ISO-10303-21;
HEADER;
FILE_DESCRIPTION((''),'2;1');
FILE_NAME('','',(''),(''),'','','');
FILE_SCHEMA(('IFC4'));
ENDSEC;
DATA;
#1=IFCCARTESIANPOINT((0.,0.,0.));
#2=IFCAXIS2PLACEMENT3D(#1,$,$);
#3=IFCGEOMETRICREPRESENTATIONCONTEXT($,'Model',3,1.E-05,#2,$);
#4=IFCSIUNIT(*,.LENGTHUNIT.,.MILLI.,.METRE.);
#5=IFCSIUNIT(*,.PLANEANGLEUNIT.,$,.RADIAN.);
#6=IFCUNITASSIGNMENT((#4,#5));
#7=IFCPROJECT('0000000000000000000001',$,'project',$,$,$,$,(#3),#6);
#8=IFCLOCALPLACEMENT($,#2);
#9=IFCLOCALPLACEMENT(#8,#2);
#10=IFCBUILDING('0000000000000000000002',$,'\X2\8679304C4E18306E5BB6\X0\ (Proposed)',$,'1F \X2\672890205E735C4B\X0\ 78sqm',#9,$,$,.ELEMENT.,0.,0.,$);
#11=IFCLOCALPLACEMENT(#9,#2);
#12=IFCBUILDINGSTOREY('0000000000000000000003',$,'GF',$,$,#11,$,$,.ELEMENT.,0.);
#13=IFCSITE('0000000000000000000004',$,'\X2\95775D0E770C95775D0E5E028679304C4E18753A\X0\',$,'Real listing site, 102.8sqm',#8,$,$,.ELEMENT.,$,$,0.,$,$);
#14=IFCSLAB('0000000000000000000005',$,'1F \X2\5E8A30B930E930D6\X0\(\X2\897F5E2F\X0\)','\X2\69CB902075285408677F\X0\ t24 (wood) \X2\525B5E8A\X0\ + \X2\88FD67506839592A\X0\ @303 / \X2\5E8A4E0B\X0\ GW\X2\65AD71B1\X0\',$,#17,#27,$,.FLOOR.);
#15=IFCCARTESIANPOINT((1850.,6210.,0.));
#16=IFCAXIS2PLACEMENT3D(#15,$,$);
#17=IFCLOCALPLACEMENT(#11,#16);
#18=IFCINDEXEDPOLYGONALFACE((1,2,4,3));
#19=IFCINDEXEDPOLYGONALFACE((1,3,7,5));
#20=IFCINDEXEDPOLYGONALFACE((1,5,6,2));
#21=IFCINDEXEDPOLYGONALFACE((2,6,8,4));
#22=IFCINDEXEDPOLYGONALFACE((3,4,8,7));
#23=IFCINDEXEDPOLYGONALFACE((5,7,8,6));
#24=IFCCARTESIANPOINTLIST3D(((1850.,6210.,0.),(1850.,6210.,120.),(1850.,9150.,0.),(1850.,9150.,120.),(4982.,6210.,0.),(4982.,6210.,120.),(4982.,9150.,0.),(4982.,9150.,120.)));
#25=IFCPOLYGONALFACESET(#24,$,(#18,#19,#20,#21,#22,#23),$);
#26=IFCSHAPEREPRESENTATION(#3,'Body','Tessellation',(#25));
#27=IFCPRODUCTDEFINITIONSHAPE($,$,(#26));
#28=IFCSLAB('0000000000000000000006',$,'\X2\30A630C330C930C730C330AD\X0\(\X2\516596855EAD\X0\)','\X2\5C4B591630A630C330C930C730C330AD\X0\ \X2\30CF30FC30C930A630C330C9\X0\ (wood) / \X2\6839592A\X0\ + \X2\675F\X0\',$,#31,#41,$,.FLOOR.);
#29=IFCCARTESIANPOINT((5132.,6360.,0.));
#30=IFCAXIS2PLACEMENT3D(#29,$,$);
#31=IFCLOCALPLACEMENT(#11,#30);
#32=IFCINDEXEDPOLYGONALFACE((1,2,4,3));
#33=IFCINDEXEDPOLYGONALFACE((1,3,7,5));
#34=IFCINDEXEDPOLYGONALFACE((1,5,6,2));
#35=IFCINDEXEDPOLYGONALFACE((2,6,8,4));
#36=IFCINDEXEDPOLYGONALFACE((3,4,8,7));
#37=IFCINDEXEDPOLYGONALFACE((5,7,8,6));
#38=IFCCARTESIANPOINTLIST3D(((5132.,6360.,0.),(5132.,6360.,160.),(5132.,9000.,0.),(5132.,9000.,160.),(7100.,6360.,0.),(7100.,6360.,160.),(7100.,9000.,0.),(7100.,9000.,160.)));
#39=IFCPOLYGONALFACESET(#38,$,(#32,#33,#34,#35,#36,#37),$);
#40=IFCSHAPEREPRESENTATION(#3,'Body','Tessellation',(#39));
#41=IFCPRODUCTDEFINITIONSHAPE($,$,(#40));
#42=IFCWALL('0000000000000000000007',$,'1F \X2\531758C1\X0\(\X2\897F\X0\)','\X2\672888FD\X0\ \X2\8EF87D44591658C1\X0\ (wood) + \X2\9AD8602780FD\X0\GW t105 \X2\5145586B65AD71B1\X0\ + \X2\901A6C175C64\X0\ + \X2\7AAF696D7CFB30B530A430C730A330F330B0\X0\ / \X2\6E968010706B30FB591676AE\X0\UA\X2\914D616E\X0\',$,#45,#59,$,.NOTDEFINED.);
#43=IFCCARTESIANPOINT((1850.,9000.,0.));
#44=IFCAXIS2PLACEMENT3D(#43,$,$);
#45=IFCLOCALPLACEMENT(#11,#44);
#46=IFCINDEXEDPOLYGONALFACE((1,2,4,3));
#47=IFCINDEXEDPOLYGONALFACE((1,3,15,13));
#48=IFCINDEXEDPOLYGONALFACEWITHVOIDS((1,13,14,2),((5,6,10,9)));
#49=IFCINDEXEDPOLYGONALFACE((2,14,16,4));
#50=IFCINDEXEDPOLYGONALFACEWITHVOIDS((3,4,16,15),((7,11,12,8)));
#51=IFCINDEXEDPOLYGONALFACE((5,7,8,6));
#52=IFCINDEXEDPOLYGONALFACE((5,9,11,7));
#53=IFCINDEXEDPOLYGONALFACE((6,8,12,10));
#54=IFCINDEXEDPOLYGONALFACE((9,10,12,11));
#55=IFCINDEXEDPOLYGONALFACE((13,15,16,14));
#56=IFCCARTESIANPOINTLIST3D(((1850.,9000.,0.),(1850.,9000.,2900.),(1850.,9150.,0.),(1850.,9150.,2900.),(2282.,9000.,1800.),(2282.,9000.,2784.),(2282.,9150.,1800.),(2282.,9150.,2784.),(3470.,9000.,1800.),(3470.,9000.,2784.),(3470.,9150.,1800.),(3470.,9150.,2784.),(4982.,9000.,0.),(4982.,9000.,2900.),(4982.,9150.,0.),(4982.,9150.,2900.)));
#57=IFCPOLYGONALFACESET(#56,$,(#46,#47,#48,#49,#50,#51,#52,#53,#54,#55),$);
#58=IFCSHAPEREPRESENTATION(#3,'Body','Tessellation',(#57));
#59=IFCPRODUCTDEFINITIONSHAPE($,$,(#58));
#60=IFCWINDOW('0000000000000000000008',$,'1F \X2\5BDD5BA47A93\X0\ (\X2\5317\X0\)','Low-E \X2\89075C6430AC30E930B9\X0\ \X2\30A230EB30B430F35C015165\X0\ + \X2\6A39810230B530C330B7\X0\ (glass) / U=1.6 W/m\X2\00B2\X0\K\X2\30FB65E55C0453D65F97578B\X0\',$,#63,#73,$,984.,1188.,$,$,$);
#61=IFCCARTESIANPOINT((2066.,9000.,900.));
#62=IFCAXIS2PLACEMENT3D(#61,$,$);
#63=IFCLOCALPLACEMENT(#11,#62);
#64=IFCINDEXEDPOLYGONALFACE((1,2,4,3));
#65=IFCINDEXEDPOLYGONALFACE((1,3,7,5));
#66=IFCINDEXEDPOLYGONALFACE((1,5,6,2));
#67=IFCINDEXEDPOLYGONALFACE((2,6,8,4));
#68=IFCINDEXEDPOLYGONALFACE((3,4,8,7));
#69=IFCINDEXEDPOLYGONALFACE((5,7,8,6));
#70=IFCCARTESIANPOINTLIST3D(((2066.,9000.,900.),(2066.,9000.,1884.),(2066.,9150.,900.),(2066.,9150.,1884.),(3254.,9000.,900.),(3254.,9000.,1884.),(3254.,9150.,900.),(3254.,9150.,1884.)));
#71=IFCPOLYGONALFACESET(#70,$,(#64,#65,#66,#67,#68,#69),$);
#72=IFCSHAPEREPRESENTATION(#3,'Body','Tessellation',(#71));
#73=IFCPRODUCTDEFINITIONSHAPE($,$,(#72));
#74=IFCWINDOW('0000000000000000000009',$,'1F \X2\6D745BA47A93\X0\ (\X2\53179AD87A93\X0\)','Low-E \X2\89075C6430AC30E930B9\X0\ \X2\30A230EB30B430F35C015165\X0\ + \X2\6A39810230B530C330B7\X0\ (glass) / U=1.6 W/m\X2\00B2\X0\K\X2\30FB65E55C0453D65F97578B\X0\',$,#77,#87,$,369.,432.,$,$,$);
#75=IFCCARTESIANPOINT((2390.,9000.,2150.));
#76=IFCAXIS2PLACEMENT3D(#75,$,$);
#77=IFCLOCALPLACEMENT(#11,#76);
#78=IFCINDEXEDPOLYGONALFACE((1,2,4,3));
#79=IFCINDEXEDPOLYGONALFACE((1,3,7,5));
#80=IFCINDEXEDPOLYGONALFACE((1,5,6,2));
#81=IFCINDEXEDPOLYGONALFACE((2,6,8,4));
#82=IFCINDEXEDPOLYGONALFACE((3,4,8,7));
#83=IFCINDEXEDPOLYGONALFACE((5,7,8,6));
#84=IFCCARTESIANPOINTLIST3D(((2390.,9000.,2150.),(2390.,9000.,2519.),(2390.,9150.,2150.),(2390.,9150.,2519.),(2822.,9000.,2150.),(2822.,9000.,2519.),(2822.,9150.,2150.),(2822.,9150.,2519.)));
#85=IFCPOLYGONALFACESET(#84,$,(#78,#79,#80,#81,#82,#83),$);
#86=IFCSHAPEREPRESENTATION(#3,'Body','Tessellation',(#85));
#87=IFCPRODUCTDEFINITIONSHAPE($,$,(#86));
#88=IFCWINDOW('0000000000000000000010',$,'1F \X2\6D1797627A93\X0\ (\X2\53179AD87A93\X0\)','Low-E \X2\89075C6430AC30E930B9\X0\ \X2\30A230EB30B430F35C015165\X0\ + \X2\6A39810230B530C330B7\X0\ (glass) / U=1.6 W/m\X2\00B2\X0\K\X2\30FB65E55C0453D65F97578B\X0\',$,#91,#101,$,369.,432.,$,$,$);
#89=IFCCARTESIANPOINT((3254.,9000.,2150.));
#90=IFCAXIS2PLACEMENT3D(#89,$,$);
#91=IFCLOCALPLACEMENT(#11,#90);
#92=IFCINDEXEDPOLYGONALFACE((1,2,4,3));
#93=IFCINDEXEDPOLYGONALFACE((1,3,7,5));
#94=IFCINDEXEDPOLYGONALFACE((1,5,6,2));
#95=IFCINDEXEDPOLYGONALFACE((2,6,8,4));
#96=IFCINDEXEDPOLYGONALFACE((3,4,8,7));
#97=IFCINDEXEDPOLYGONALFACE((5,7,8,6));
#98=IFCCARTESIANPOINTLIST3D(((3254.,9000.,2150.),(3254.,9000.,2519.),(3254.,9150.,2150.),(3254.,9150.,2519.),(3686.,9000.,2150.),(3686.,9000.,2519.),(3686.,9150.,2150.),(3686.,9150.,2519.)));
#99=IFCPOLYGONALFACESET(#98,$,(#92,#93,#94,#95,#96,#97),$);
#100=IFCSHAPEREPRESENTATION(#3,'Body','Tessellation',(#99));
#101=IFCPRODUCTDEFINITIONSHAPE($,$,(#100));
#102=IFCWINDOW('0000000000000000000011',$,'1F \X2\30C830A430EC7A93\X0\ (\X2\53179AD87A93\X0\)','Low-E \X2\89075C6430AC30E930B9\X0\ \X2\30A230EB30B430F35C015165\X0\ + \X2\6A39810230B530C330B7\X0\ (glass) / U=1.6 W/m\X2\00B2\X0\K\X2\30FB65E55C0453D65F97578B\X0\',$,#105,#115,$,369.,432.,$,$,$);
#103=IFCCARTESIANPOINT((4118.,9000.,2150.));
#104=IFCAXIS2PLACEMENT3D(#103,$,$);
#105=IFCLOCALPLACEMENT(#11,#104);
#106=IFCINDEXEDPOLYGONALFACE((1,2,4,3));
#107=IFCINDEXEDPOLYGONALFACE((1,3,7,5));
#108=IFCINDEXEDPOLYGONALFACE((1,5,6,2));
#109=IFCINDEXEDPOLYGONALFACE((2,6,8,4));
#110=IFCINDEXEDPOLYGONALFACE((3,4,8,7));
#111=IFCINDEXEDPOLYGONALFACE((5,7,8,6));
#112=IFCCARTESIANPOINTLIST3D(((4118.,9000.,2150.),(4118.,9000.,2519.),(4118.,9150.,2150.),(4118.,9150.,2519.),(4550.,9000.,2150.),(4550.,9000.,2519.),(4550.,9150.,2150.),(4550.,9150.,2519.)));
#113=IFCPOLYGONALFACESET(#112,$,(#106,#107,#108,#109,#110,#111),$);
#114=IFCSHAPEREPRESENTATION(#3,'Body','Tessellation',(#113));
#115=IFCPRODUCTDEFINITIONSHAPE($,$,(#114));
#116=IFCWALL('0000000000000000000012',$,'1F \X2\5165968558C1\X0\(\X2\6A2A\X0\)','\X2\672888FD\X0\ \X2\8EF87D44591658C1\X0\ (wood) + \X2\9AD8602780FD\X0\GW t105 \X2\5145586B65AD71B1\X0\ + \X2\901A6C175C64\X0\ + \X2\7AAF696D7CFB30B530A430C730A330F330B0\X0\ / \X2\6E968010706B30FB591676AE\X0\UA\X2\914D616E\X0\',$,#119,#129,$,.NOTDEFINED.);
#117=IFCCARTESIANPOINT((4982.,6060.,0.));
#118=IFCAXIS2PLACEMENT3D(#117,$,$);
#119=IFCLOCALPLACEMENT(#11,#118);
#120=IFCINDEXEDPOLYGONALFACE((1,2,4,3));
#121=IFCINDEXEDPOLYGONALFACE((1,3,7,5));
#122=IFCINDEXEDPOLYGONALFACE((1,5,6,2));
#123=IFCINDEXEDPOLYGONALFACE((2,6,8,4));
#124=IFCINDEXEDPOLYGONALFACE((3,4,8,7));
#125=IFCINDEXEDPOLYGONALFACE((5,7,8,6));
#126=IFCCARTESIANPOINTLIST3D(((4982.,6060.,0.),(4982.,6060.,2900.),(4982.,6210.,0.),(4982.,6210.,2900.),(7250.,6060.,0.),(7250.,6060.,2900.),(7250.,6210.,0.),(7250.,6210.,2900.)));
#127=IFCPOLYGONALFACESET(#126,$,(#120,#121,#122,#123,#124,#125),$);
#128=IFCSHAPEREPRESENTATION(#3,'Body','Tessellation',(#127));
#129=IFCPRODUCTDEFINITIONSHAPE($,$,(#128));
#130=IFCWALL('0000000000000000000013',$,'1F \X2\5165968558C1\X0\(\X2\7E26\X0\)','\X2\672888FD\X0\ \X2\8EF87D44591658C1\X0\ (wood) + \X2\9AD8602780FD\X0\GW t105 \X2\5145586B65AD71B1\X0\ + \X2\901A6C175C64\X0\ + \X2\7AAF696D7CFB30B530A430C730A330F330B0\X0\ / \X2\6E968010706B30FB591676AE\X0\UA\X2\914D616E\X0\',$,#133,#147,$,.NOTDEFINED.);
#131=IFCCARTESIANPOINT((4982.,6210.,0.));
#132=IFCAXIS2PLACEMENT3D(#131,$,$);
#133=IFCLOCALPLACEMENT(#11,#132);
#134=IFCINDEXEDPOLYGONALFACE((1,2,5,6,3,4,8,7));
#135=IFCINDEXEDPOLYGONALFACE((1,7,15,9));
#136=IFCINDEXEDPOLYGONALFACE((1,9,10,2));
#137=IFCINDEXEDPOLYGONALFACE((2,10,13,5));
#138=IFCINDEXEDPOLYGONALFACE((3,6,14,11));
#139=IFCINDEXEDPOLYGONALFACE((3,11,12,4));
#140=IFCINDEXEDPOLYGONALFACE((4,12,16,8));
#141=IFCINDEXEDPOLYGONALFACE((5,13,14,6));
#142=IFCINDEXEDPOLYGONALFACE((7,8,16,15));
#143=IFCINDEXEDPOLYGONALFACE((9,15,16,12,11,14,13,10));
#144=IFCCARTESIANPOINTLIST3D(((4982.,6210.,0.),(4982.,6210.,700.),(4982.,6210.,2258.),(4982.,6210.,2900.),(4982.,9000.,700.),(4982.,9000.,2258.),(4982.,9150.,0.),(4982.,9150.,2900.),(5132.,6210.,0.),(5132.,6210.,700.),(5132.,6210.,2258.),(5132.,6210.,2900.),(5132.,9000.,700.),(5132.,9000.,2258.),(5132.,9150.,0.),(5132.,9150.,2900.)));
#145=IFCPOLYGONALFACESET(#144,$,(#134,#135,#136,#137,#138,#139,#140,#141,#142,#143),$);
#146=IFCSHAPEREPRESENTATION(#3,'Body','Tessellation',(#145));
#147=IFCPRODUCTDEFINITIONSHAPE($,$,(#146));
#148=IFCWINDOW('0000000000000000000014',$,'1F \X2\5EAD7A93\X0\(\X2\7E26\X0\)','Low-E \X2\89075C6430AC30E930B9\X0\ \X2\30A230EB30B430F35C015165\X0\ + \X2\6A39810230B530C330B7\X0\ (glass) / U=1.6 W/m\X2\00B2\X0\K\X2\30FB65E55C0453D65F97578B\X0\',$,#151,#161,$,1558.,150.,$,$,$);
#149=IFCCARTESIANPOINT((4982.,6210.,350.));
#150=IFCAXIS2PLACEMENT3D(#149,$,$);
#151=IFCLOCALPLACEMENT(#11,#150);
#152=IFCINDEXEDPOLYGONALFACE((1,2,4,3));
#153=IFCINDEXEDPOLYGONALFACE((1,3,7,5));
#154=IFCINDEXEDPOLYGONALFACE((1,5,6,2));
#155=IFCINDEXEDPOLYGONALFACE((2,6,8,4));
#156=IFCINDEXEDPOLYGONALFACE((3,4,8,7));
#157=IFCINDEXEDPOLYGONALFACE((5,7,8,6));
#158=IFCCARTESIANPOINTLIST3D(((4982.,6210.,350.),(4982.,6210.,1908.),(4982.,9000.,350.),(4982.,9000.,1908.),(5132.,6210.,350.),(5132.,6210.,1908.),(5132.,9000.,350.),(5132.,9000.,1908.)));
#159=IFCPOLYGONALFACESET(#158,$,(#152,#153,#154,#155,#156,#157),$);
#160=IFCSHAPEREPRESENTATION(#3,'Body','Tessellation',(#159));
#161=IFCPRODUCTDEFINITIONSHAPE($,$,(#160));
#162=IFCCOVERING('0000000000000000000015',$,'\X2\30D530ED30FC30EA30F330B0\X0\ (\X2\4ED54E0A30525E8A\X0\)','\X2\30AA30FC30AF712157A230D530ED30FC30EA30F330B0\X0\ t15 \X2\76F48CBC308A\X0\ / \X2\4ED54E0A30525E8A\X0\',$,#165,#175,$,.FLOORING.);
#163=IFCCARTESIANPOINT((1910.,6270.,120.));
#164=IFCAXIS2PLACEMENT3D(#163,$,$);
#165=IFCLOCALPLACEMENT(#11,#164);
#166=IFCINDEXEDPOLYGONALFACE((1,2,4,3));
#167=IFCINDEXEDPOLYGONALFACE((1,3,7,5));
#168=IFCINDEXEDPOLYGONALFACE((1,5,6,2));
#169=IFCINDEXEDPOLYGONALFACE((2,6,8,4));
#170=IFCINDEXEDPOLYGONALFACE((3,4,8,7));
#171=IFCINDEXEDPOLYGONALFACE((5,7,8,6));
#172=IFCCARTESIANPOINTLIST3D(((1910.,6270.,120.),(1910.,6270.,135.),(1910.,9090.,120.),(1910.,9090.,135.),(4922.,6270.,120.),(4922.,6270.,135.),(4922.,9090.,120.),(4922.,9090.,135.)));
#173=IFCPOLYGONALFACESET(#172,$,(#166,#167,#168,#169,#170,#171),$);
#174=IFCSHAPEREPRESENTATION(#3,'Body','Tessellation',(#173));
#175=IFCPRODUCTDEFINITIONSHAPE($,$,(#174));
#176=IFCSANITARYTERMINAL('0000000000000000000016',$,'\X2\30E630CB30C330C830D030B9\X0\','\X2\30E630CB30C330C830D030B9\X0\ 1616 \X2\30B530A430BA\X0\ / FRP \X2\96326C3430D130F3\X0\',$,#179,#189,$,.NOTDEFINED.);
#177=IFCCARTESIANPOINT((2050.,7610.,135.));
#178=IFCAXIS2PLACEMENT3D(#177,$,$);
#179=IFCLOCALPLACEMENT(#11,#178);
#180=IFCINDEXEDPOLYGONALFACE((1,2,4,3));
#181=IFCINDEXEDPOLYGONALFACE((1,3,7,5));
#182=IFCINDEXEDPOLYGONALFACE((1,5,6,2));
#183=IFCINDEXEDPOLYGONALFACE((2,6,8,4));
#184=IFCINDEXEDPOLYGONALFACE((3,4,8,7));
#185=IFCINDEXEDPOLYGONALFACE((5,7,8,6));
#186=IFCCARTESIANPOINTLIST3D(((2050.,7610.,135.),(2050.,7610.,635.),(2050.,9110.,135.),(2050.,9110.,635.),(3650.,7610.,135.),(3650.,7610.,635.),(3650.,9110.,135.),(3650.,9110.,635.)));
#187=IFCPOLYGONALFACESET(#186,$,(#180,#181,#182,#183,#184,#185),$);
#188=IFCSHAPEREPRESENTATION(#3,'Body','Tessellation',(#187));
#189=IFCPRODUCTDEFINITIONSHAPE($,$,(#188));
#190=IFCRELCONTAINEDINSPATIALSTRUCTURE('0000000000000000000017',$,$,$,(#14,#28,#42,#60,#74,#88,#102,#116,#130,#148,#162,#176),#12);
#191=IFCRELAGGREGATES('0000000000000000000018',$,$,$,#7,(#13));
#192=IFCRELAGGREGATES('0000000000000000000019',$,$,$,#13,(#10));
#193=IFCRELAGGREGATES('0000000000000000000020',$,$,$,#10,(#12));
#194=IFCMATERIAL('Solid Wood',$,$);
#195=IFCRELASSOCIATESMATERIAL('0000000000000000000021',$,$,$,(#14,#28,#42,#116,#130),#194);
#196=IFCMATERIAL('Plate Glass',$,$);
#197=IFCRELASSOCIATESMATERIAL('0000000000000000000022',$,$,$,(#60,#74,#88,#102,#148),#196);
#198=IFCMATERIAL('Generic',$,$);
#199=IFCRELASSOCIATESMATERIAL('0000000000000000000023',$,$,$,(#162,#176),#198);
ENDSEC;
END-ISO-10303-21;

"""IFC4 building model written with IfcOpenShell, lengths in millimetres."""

from ifc_helpers import new_model, si_unit, frame, frame_2d, origin, place, context, project, spatial, rectangle, extrude, material, element, fill, save


model = new_model("IFC4")

# Units and contexts
model_context = context("Model", 3, precision=1e-05, world=origin())
ifc_project = project(units=[si_unit("LENGTHUNIT", "METRE", prefix="MILLI"), si_unit("PLANEANGLEUNIT", "RADIAN")], contexts=[model_context])

# Site, building, storey
site_placement = place(None, origin())
site = spatial("IfcSite", under=ifc_project, at=site_placement, Name="長崎県長崎市虹が丘町", ObjectType="Real listing site, 102.8sqm", CompositionType="ELEMENT", RefElevation=0.0)
building_placement = place(site_placement, origin())
building = spatial("IfcBuilding", under=site, at=building_placement, Name="虹が丘の家 (Proposed)", ObjectType="1F 木造平屋 78sqm", CompositionType="ELEMENT", ElevationOfRefHeight=0.0, ElevationOfTerrain=0.0)
storey_placement = place(building_placement, origin())
storey = spatial("IfcBuildingStorey", under=building, at=storey_placement, Name="GF", CompositionType="ELEMENT", Elevation=0.0)

# Slabs
ifc_material_1 = material(Name="Solid Wood")
slab_1_placement = place(storey_placement, frame((1850.0, 6210.0, 0.0)))
element("IfcSlab", 1, at=slab_1_placement, inside=storey, material=ifc_material_1, Name="1F 床スラブ(西帯)", Description="構造用合板 t24 (wood) 剛床 + 製材根太 @303 / 床下 GW断熱", PredefinedType="FLOOR", context=model_context, shape_type="SweptSolid", body=[
    extrude(rectangle(XDim=3132.0, YDim=2940.0, at=frame_2d((1566.0, 1470.0))), frame((1850.0, 6210.0, 0.0)), (0.0, 0.0, 1.0), 120.0),
])
slab_2_placement = place(storey_placement, frame((5132.0, 6360.0, 0.0)))
element("IfcSlab", 2, at=slab_2_placement, inside=storey, material=ifc_material_1, Name="ウッドデッキ(入隅庭)", Description="屋外ウッドデッキ ハードウッド (wood) / 根太 + 束", PredefinedType="FLOOR", context=model_context, shape_type="SweptSolid", body=[
    extrude(rectangle(XDim=1968.0, YDim=2640.0, at=frame_2d((984.0, 1320.0))), frame((5132.0, 6360.0, 0.0)), (0.0, 0.0, 1.0), 160.0),
])

# Wall, openings, windows
wall_1_placement = place(storey_placement, frame((1850.0, 9000.0, 0.0)))
wall_1 = element("IfcWall", 3, at=wall_1_placement, inside=storey, material=ifc_material_1, Name="1F 北壁(西)", Description="木製 軸組外壁 (wood) + 高性能GW t105 充填断熱 + 通気層 + 窯業系サイディング / 準耐火・外皮UA配慮", PredefinedType="NOTDEFINED", context=model_context, shape_type="SweptSolid", body=[
    extrude(rectangle(XDim=3132.0, YDim=150.0, at=frame_2d((1566.0, 75.0))), frame((1850.0, 9000.0, 0.0)), (0.0, 0.0, 1.0), 2900.0),
])
opening_1_placement = place(storey_placement, frame((2066.0, 9000.0, 900.0)))
opening_1 = element("IfcOpeningElement", 4, at=opening_1_placement, cuts=wall_1, PredefinedType="NOTDEFINED", context=model_context, shape_type="SweptSolid", body=[
    extrude(rectangle(XDim=1188.0, YDim=150.0, at=frame_2d((594.0, 75.0))), frame((2066.0, 9000.0, 900.0)), (0.0, 0.0, 1.0), 984.0),
])
opening_2_placement = place(storey_placement, frame((2390.0, 9000.0, 2150.0)))
opening_2 = element("IfcOpeningElement", 5, at=opening_2_placement, cuts=wall_1, PredefinedType="NOTDEFINED", context=model_context, shape_type="SweptSolid", body=[
    extrude(rectangle(XDim=432.0, YDim=150.0, at=frame_2d((216.0, 75.0))), frame((2390.0, 9000.0, 2150.0)), (0.0, 0.0, 1.0), 369.0),
])
opening_3_placement = place(storey_placement, frame((3254.0, 9000.0, 2150.0)))
opening_3 = element("IfcOpeningElement", 6, at=opening_3_placement, cuts=wall_1, PredefinedType="NOTDEFINED", context=model_context, shape_type="SweptSolid", body=[
    extrude(rectangle(XDim=432.0, YDim=150.0, at=frame_2d((216.0, 75.0))), frame((3254.0, 9000.0, 2150.0)), (0.0, 0.0, 1.0), 369.0),
])
opening_4_placement = place(storey_placement, frame((4118.0, 9000.0, 2150.0)))
opening_4 = element("IfcOpeningElement", 7, at=opening_4_placement, cuts=wall_1, PredefinedType="NOTDEFINED", context=model_context, shape_type="SweptSolid", body=[
    extrude(rectangle(XDim=432.0, YDim=150.0, at=frame_2d((216.0, 75.0))), frame((4118.0, 9000.0, 2150.0)), (0.0, 0.0, 1.0), 369.0),
])
ifc_material_2 = material(Name="Plate Glass")
window_1_placement = place(storey_placement, frame((2066.0, 9000.0, 900.0)))
window_1 = element("IfcWindow", 8, at=window_1_placement, inside=storey, material=ifc_material_2, Name="1F 寝室窓 (北)", Description="Low-E 複層ガラス アルゴン封入 + 樹脂サッシ (glass) / U=1.6 W/m²K・日射取得型", OverallHeight=984.0, OverallWidth=1188.0, context=model_context, shape_type="SweptSolid", body=[
    extrude(rectangle(XDim=1188.0, YDim=150.0, at=frame_2d((594.0, 75.0))), frame((2066.0, 9000.0, 900.0)), (0.0, 0.0, 1.0), 984.0),
])
fill(opening_1, window_1)
window_2_placement = place(storey_placement, frame((2390.0, 9000.0, 2150.0)))
window_2 = element("IfcWindow", 9, at=window_2_placement, inside=storey, material=ifc_material_2, Name="1F 浴室窓 (北高窓)", Description="Low-E 複層ガラス アルゴン封入 + 樹脂サッシ (glass) / U=1.6 W/m²K・日射取得型", OverallHeight=369.0, OverallWidth=432.0, context=model_context, shape_type="SweptSolid", body=[
    extrude(rectangle(XDim=432.0, YDim=150.0, at=frame_2d((216.0, 75.0))), frame((2390.0, 9000.0, 2150.0)), (0.0, 0.0, 1.0), 369.0),
])
fill(opening_2, window_2)
window_3_placement = place(storey_placement, frame((3254.0, 9000.0, 2150.0)))
window_3 = element("IfcWindow", 10, at=window_3_placement, inside=storey, material=ifc_material_2, Name="1F 洗面窓 (北高窓)", Description="Low-E 複層ガラス アルゴン封入 + 樹脂サッシ (glass) / U=1.6 W/m²K・日射取得型", OverallHeight=369.0, OverallWidth=432.0, context=model_context, shape_type="SweptSolid", body=[
    extrude(rectangle(XDim=432.0, YDim=150.0, at=frame_2d((216.0, 75.0))), frame((3254.0, 9000.0, 2150.0)), (0.0, 0.0, 1.0), 369.0),
])
fill(opening_3, window_3)
window_4_placement = place(storey_placement, frame((4118.0, 9000.0, 2150.0)))
window_4 = element("IfcWindow", 11, at=window_4_placement, inside=storey, material=ifc_material_2, Name="1F トイレ窓 (北高窓)", Description="Low-E 複層ガラス アルゴン封入 + 樹脂サッシ (glass) / U=1.6 W/m²K・日射取得型", OverallHeight=369.0, OverallWidth=432.0, context=model_context, shape_type="SweptSolid", body=[
    extrude(rectangle(XDim=432.0, YDim=150.0, at=frame_2d((216.0, 75.0))), frame((4118.0, 9000.0, 2150.0)), (0.0, 0.0, 1.0), 369.0),
])
fill(opening_4, window_4)

# Wall
wall_2_placement = place(storey_placement, frame((4982.0, 6060.0, 0.0)))
element("IfcWall", 12, at=wall_2_placement, inside=storey, material=ifc_material_1, Name="1F 入隅壁(横)", Description="木製 軸組外壁 (wood) + 高性能GW t105 充填断熱 + 通気層 + 窯業系サイディング / 準耐火・外皮UA配慮", PredefinedType="NOTDEFINED", context=model_context, shape_type="SweptSolid", body=[
    extrude(rectangle(XDim=2268.0, YDim=150.0, at=frame_2d((1134.0, 75.0))), frame((4982.0, 6060.0, 0.0)), (0.0, 0.0, 1.0), 2900.0),
])

# Wall, opening, window
wall_3_placement = place(storey_placement, frame((4982.0, 6210.0, 0.0)))
wall_3 = element("IfcWall", 13, at=wall_3_placement, inside=storey, material=ifc_material_1, Name="1F 入隅壁(縦)", Description="木製 軸組外壁 (wood) + 高性能GW t105 充填断熱 + 通気層 + 窯業系サイディング / 準耐火・外皮UA配慮", PredefinedType="NOTDEFINED", context=model_context, shape_type="SweptSolid", body=[
    extrude(rectangle(XDim=150.0, YDim=2940.0, at=frame_2d((75.0, 1470.0))), frame((4982.0, 6210.0, 0.0)), (0.0, 0.0, 1.0), 2900.0),
])
opening_5_placement = place(storey_placement, frame((4982.0, 6210.0, 350.0)))
opening_5 = element("IfcOpeningElement", 14, at=opening_5_placement, cuts=wall_3, PredefinedType="NOTDEFINED", context=model_context, shape_type="SweptSolid", body=[
    extrude(rectangle(XDim=150.0, YDim=2790.0, at=frame_2d((75.0, 1395.0))), frame((4982.0, 6210.0, 350.0)), (0.0, 0.0, 1.0), 1558.0),
])
window_5_placement = place(storey_placement, frame((4982.0, 6210.0, 350.0)))
window_5 = element("IfcWindow", 15, at=window_5_placement, inside=storey, material=ifc_material_2, Name="1F 庭窓(縦)", Description="Low-E 複層ガラス アルゴン封入 + 樹脂サッシ (glass) / U=1.6 W/m²K・日射取得型", OverallHeight=1558.0, OverallWidth=150.0, context=model_context, shape_type="SweptSolid", body=[
    extrude(rectangle(XDim=150.0, YDim=2790.0, at=frame_2d((75.0, 1395.0))), frame((4982.0, 6210.0, 350.0)), (0.0, 0.0, 1.0), 1558.0),
])
fill(opening_5, window_5)

# Covering
ifc_material_3 = material(Name="Generic")
covering_placement = place(storey_placement, frame((1910.0, 6270.0, 120.0)))
element("IfcCovering", 16, at=covering_placement, inside=storey, material=ifc_material_3, Name="フローリング (仕上げ床)", Description="オーク無垢フローリング t15 直貼り / 仕上げ床", PredefinedType="FLOORING", context=model_context, shape_type="SweptSolid", body=[
    extrude(rectangle(XDim=3012.0, YDim=2820.0, at=frame_2d((1506.0, 1410.0))), frame((1910.0, 6270.0, 120.0)), (0.0, 0.0, 1.0), 15.0),
])

# Sanitary terminal
sanitary_terminal_1_placement = place(storey_placement, frame((2050.0, 7610.0, 135.0)))
element("IfcSanitaryTerminal", 17, at=sanitary_terminal_1_placement, inside=storey, material=ifc_material_3, Name="ユニットバス", Description="ユニットバス 1616 サイズ / FRP 防水パン", PredefinedType="NOTDEFINED", context=model_context, shape_type="SweptSolid", body=[
    extrude(rectangle(XDim=1600.0, YDim=1500.0, at=frame_2d((800.0, 750.0))), frame((2050.0, 7610.0, 135.0)), (0.0, 0.0, 1.0), 500.0),
])

save(model, "model.ifc")
